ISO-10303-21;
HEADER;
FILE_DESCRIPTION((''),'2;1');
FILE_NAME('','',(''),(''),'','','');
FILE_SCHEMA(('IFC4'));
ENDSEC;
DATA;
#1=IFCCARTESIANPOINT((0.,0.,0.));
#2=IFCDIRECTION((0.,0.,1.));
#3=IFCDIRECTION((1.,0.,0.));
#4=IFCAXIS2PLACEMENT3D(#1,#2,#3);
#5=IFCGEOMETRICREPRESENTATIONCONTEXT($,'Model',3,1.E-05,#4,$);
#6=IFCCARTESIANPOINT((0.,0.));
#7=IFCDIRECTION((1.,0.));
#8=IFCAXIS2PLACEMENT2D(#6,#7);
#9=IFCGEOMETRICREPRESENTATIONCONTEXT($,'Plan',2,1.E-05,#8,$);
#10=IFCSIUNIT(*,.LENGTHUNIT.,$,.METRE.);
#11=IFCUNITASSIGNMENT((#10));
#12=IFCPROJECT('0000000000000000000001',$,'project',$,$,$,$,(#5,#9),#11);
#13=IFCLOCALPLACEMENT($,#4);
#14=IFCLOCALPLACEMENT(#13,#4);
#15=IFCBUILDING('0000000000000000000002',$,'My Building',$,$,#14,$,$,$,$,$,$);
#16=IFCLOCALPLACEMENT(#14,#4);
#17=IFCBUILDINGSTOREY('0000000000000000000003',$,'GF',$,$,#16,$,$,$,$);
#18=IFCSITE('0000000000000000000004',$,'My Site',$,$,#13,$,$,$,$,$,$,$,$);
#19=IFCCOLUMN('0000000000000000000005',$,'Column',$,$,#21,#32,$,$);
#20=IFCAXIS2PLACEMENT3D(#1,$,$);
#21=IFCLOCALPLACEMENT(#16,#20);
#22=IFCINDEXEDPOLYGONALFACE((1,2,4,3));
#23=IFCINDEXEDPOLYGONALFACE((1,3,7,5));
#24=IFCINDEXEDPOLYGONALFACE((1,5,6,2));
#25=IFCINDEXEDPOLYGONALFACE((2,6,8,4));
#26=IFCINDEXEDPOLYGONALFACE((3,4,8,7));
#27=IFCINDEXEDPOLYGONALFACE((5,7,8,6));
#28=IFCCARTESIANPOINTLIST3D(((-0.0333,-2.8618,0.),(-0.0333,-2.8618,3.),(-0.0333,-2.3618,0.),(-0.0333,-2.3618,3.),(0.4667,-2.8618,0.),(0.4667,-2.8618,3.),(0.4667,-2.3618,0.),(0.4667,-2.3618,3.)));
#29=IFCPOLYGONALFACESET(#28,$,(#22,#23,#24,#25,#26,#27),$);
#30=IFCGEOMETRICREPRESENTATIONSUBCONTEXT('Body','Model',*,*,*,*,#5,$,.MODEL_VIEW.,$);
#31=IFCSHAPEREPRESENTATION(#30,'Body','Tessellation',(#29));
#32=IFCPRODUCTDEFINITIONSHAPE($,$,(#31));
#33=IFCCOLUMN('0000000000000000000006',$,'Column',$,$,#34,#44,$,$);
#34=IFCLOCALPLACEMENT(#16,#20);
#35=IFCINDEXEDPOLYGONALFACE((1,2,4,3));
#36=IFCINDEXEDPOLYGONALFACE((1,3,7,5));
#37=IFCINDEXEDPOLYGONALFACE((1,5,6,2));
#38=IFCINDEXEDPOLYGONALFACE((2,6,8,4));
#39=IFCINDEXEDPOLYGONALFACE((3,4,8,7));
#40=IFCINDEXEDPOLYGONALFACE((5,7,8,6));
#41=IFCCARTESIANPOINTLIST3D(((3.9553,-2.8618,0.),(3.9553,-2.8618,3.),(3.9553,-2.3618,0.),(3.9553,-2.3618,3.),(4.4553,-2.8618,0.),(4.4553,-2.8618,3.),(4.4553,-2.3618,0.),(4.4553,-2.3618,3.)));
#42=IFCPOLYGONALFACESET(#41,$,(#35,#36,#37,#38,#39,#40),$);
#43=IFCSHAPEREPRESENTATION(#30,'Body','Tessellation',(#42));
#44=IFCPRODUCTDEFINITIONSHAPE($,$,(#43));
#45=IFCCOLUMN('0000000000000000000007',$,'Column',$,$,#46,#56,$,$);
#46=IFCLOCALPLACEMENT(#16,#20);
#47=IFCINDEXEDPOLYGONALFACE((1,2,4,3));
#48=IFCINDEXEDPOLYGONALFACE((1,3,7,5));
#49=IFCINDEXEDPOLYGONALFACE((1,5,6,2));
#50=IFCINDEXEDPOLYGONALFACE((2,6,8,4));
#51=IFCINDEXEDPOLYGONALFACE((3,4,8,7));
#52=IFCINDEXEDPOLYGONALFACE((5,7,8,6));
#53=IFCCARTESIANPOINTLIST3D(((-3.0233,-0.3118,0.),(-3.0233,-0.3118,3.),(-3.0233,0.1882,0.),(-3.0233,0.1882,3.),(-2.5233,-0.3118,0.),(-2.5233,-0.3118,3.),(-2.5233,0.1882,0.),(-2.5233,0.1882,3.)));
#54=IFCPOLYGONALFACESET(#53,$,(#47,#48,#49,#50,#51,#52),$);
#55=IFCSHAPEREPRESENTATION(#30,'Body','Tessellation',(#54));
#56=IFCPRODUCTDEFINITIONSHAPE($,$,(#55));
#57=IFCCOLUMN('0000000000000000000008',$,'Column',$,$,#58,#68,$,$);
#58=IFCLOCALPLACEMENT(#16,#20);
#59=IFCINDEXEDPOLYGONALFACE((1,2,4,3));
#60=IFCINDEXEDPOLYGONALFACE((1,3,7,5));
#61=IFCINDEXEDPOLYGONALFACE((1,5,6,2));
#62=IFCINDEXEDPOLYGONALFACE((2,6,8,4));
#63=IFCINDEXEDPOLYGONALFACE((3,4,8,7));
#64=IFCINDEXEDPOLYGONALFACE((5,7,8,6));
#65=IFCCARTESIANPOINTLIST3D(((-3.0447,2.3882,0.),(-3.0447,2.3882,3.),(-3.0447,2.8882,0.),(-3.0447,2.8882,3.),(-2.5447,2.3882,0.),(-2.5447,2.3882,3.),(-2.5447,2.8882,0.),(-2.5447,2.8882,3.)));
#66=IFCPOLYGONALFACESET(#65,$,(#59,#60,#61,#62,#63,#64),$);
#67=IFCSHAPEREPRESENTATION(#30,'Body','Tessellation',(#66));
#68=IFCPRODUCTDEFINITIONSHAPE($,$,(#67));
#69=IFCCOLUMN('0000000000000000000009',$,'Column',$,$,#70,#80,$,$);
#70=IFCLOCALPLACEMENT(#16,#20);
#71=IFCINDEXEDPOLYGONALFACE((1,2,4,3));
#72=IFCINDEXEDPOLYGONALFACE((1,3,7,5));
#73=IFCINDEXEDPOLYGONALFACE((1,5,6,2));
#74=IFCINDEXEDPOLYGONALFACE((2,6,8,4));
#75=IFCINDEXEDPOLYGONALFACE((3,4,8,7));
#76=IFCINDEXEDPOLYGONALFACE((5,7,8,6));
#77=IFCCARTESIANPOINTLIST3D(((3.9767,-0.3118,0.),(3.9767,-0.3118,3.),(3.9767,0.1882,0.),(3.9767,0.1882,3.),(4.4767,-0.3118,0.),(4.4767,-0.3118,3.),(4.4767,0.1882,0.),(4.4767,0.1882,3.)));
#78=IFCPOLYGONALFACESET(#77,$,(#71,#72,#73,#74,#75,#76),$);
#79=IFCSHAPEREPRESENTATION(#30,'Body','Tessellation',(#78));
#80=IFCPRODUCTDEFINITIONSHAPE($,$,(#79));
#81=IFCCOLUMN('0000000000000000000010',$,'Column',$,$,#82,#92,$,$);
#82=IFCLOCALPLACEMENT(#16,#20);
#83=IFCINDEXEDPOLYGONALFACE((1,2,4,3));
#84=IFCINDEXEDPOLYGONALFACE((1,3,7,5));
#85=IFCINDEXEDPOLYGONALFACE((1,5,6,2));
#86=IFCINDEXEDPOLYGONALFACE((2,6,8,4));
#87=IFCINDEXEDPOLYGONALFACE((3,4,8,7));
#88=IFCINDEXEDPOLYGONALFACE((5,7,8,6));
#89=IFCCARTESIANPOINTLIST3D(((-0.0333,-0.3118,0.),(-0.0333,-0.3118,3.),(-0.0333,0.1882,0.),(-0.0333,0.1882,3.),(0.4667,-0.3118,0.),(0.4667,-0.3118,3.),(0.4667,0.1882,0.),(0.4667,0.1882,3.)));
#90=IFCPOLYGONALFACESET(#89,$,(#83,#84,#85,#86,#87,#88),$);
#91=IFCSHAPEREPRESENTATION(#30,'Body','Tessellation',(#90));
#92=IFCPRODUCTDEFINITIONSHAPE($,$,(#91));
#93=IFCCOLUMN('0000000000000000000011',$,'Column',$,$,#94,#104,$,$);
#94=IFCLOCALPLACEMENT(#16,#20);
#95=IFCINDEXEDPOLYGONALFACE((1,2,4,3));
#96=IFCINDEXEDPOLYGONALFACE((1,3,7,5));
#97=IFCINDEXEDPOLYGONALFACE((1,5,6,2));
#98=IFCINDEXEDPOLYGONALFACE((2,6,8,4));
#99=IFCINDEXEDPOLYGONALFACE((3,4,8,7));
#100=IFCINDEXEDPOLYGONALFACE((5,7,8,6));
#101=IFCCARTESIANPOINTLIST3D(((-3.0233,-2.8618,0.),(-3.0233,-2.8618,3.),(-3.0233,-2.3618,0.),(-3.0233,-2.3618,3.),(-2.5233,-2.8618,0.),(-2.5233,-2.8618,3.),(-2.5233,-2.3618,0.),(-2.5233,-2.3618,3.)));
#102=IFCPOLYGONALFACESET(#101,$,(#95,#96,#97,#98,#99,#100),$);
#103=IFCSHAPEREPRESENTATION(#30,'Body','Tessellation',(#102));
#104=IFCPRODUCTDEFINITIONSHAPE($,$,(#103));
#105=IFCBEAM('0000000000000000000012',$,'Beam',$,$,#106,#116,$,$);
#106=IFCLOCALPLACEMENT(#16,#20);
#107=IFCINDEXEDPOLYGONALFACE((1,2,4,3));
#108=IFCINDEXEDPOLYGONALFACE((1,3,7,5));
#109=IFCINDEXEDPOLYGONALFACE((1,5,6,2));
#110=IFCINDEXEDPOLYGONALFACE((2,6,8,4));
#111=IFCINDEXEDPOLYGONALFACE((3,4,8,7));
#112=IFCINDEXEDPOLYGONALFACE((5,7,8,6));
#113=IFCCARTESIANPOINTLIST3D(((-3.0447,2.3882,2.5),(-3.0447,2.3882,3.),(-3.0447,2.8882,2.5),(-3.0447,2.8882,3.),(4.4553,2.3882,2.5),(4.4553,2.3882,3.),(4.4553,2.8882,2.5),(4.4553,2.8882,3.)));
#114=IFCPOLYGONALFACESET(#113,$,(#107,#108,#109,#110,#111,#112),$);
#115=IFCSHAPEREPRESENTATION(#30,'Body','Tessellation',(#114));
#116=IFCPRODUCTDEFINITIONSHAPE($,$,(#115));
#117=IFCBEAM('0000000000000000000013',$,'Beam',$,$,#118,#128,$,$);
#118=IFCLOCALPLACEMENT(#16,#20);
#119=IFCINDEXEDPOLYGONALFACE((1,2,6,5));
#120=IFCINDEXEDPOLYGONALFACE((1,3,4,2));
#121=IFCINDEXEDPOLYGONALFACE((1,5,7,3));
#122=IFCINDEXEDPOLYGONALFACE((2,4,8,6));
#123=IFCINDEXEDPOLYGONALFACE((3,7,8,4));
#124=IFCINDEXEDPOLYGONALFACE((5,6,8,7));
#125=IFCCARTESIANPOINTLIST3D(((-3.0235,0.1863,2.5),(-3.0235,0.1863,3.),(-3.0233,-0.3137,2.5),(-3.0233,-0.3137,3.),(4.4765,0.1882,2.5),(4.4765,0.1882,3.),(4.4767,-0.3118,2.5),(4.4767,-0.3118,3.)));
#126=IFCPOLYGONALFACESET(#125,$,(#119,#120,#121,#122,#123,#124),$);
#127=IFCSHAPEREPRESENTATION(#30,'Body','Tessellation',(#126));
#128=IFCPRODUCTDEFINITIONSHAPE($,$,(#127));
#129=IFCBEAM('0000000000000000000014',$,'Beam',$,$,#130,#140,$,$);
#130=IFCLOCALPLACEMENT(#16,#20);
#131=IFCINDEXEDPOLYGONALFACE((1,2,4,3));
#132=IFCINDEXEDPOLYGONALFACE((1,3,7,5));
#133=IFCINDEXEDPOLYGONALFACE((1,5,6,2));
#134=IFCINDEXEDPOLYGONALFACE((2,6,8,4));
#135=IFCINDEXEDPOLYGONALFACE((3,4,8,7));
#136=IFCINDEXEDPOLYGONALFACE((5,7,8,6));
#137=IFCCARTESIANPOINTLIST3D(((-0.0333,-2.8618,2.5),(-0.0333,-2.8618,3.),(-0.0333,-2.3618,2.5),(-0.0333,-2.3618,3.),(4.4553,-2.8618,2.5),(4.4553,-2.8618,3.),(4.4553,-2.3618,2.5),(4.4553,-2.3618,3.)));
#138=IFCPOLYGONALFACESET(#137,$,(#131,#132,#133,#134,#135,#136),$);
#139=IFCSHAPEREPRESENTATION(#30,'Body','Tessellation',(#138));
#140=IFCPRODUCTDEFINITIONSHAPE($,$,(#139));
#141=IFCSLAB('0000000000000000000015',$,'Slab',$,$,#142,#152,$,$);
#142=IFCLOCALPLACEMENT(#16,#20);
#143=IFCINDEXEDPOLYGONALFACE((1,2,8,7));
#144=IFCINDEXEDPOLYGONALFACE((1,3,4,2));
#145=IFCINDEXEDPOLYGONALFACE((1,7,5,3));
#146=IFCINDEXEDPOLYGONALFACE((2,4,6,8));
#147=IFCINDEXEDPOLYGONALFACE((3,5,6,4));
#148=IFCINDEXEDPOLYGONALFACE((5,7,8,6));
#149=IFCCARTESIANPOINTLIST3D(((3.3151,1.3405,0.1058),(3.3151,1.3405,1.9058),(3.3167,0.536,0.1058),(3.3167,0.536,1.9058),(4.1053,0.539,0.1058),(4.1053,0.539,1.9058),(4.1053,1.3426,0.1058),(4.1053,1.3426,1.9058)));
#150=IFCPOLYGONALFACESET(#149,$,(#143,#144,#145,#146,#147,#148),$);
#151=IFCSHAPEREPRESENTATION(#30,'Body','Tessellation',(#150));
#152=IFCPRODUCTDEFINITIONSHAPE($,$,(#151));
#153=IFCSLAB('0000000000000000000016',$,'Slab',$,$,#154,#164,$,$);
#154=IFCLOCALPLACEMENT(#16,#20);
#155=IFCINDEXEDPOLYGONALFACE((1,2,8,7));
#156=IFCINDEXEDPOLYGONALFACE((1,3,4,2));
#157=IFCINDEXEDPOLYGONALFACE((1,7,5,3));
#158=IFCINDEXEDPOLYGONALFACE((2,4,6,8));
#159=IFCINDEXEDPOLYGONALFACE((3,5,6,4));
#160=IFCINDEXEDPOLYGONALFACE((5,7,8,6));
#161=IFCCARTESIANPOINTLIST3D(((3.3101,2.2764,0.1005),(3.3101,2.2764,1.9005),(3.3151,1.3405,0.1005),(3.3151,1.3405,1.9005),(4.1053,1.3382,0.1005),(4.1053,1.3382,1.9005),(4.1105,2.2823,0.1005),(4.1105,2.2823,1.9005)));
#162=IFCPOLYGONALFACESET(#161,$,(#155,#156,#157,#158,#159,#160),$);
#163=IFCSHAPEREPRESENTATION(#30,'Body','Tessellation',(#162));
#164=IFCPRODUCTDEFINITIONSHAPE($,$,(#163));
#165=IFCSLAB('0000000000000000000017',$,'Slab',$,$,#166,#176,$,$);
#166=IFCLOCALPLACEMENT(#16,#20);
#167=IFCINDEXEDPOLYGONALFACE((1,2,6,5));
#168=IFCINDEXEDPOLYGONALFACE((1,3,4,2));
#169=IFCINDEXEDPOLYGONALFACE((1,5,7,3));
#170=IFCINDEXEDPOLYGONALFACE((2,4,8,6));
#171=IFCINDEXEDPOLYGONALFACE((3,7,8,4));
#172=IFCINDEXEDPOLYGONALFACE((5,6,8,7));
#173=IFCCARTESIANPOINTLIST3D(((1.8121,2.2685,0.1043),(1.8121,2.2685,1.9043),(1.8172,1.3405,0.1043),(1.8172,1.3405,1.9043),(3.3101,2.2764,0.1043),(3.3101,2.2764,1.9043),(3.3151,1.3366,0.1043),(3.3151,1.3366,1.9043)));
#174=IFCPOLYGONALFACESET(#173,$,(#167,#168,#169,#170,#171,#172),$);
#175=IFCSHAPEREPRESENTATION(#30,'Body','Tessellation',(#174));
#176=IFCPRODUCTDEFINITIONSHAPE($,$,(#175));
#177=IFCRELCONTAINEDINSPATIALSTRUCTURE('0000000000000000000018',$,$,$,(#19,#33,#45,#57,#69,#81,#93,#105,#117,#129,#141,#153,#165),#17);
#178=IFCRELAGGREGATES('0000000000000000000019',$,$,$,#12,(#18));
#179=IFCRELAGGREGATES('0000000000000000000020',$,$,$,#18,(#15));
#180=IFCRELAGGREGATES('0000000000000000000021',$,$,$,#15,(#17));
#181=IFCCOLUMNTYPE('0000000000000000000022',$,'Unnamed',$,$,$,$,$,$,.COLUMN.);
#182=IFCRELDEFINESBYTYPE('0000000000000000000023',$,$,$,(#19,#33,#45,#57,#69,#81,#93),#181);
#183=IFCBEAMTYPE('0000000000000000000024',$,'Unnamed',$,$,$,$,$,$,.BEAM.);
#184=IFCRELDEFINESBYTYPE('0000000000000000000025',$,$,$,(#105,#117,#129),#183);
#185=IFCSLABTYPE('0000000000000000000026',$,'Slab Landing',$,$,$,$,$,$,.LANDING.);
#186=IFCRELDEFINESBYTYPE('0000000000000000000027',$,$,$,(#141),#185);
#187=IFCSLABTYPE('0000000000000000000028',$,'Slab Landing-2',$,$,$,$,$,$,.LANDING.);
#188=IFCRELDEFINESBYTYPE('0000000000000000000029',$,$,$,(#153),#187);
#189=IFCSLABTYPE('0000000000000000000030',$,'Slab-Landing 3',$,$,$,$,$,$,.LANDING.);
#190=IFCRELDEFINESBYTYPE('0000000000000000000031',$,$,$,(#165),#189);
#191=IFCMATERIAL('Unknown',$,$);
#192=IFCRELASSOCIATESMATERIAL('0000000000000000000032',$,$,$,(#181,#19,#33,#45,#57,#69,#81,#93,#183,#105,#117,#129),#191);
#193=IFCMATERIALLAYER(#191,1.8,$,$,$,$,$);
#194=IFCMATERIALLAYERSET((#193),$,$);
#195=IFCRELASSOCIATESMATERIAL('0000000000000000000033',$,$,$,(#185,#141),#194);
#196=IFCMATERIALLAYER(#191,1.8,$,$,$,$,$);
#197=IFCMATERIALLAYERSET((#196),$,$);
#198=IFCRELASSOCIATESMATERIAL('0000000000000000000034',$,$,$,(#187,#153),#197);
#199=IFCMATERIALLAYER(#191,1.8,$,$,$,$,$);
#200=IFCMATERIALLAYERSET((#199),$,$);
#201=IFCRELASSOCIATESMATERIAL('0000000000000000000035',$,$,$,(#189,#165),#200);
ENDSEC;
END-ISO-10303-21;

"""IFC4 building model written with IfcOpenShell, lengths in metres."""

from ifc_helpers import new_model, si_unit, frame, origin_with_axes, origin_2d_with_axis, place, context, subcontext, project, spatial, indexed_curve, rectangle, outline, extrude, material, layer, layer_set, layer_usage, material_profile, profile_set, profile_usage, type_object, element, save


model = new_model("IFC4")

# Units and contexts
model_context = context("Model", 3, precision=1e-05, world=origin_with_axes())
plan_context = context("Plan", 2, precision=1e-05, world=origin_2d_with_axis())
body_context_1 = subcontext(model_context, "Body", "Model", "MODEL_VIEW")
ifc_project = project(units=[si_unit("LENGTHUNIT", "METRE")], contexts=[model_context, plan_context])

# Site, building, storey
site_placement = place(None, origin_with_axes())
site = spatial("IfcSite", under=ifc_project, at=site_placement, Name="My Site")
building_placement = place(site_placement, origin_with_axes())
building = spatial("IfcBuilding", under=site, at=building_placement, Name="My Building")
storey_placement = place(building_placement, origin_with_axes())
storey = spatial("IfcBuildingStorey", under=building, at=storey_placement, Name="GF")

# Columns
ifc_material = material(Name="Unknown")
ifc_material_profile_1 = material_profile(ifc_material, rectangle(XDim=0.5, YDim=0.5))
ifc_profile_set_1 = profile_set([ifc_material_profile_1])
ifc_profile_usage_1 = profile_usage(ifc_profile_set_1, cardinal=5)
column_type = type_object("IfcColumnType", Name="Unnamed", PredefinedType="COLUMN", material=ifc_profile_set_1)
column_1_placement = place(storey_placement, frame((0.2167, -2.6118, 0.0), z_axis=(0.0, 0.0, 1.0), x_axis=(1.0, 0.0, 0.0)))
element("IfcColumn", 1, at=column_1_placement, inside=storey, type_object=column_type, material=ifc_profile_usage_1, Name="Column", context=body_context_1, shape_type="SweptSolid", body=[
    extrude(rectangle(XDim=0.5, YDim=0.5), origin_with_axes(), (0.0, 0.0, 1.0), 3.0),
])
ifc_profile_usage_2 = profile_usage(ifc_profile_set_1, cardinal=5)
column_2_placement = place(storey_placement, frame((4.2053, -2.6118, 0.0), z_axis=(0.0, 0.0, 1.0), x_axis=(1.0, 0.0, 0.0)))
element("IfcColumn", 2, at=column_2_placement, inside=storey, type_object=column_type, material=ifc_profile_usage_2, Name="Column", context=body_context_1, shape_type="SweptSolid", body=[
    extrude(rectangle(XDim=0.5, YDim=0.5), origin_with_axes(), (0.0, 0.0, 1.0), 3.0),
])
ifc_profile_usage_3 = profile_usage(ifc_profile_set_1, cardinal=5)
column_3_placement = place(storey_placement, frame((-2.7733, -0.0618, 0.0), z_axis=(0.0, 0.0, 1.0), x_axis=(1.0, 0.0, 0.0)))
element("IfcColumn", 3, at=column_3_placement, inside=storey, type_object=column_type, material=ifc_profile_usage_3, Name="Column", context=body_context_1, shape_type="SweptSolid", body=[
    extrude(rectangle(XDim=0.5, YDim=0.5), origin_with_axes(), (0.0, 0.0, 1.0), 3.0),
])
ifc_profile_usage_4 = profile_usage(ifc_profile_set_1, cardinal=5)
column_4_placement = place(storey_placement, frame((-2.7947, 2.6382, 0.0), z_axis=(0.0, 0.0, 1.0), x_axis=(1.0, 0.0, 0.0)))
element("IfcColumn", 4, at=column_4_placement, inside=storey, type_object=column_type, material=ifc_profile_usage_4, Name="Column", context=body_context_1, shape_type="SweptSolid", body=[
    extrude(rectangle(XDim=0.5, YDim=0.5), origin_with_axes(), (0.0, 0.0, 1.0), 3.0),
])
ifc_profile_usage_5 = profile_usage(ifc_profile_set_1, cardinal=5)
column_5_placement = place(storey_placement, frame((4.2267, -0.0618, 0.0), z_axis=(0.0, 0.0, 1.0), x_axis=(1.0, 0.0, 0.0)))
element("IfcColumn", 5, at=column_5_placement, inside=storey, type_object=column_type, material=ifc_profile_usage_5, Name="Column", context=body_context_1, shape_type="SweptSolid", body=[
    extrude(rectangle(XDim=0.5, YDim=0.5), origin_with_axes(), (0.0, 0.0, 1.0), 3.0),
])
ifc_profile_usage_6 = profile_usage(ifc_profile_set_1, cardinal=5)
column_6_placement = place(storey_placement, frame((0.2167, -0.0618, 0.0), z_axis=(0.0, 0.0, 1.0), x_axis=(1.0, 0.0, 0.0)))
element("IfcColumn", 6, at=column_6_placement, inside=storey, type_object=column_type, material=ifc_profile_usage_6, Name="Column", context=body_context_1, shape_type="SweptSolid", body=[
    extrude(rectangle(XDim=0.5, YDim=0.5), origin_with_axes(), (0.0, 0.0, 1.0), 3.0),
])
ifc_profile_usage_7 = profile_usage(ifc_profile_set_1, cardinal=5)
column_7_placement = place(storey_placement, frame((-2.7733, -2.6118, 0.0), z_axis=(0.0, 0.0, 1.0), x_axis=(1.0, 0.0, 0.0)))
element("IfcColumn", 7, at=column_7_placement, inside=storey, type_object=column_type, material=ifc_profile_usage_7, Name="Column", context=body_context_1, shape_type="SweptSolid", body=[
    extrude(rectangle(XDim=0.5, YDim=0.5), origin_with_axes(), (0.0, 0.0, 1.0), 3.0),
])

# Beams
ifc_material_profile_2 = material_profile(ifc_material, rectangle(XDim=0.5, YDim=0.5))
ifc_profile_set_2 = profile_set([ifc_material_profile_2])
ifc_profile_usage_8 = profile_usage(ifc_profile_set_2, cardinal=7)
beam_type = type_object("IfcBeamType", Name="Unnamed", PredefinedType="BEAM", material=ifc_profile_set_2)
beam_1_placement = place(storey_placement, frame((4.4553, 2.3882, 3.0), z_axis=(-1.0, 0.0, 0.0), x_axis=(0.0, -1.0, 0.0)))
element("IfcBeam", 8, at=beam_1_placement, inside=storey, type_object=beam_type, material=ifc_profile_usage_8, Name="Beam", context=body_context_1, shape_type="SweptSolid", body=[
    extrude(rectangle(XDim=0.5, YDim=0.5), frame((-0.25, -0.25, 0.0), z_axis=(0.0, 0.0, 1.0), x_axis=(1.0, 0.0, 0.0)), (0.0, 0.0, 1.0), 7.5),
])
ifc_profile_usage_9 = profile_usage(ifc_profile_set_2, cardinal=7)
beam_2_placement = place(storey_placement, frame((4.4767, -0.3118, 3.0), z_axis=(-1.0, -0.000255, 0.0), x_axis=(0.000255, -1.0, 0.0)))
element("IfcBeam", 9, at=beam_2_placement, inside=storey, type_object=beam_type, material=ifc_profile_usage_9, Name="Beam", context=body_context_1, shape_type="SweptSolid", body=[
    extrude(rectangle(XDim=0.5, YDim=0.5), frame((-0.25, -0.25, 0.0), z_axis=(0.0, 0.0, 1.0), x_axis=(1.0, 0.0, 0.0)), (0.0, 0.0, 1.0), 7.5),
])
ifc_profile_usage_10 = profile_usage(ifc_profile_set_2, cardinal=7)
beam_3_placement = place(storey_placement, frame((4.4553, -2.8618, 3.0), z_axis=(-1.0, 0.0, 0.0), x_axis=(0.0, -1.0, 0.0)))
element("IfcBeam", 10, at=beam_3_placement, inside=storey, type_object=beam_type, material=ifc_profile_usage_10, Name="Beam", context=body_context_1, shape_type="SweptSolid", body=[
    extrude(rectangle(XDim=0.5, YDim=0.5), frame((-0.25, -0.25, 0.0), z_axis=(0.0, 0.0, 1.0), x_axis=(1.0, 0.0, 0.0)), (0.0, 0.0, 1.0), 4.4886),
])

# Slabs
ifc_layer_1 = layer(ifc_material, 1.8)
ifc_layer_set_1 = layer_set([ifc_layer_1])
ifc_layer_usage_1 = layer_usage(ifc_layer_set_1, "AXIS3", "POSITIVE", -0.1)
slab_type_1 = type_object("IfcSlabType", Name="Slab Landing", PredefinedType="LANDING", material=ifc_layer_set_1)
slab_1_placement = place(storey_placement, frame((3.3167, 0.536, 0.2058), z_axis=(0.0, 0.0, 1.0), x_axis=(1.0, 0.0, 0.0)))
element("IfcSlab", 11, at=slab_1_placement, inside=storey, type_object=slab_type_1, material=ifc_layer_usage_1, Name="Slab", context=body_context_1, shape_type="SweptSolid", body=[
    extrude(outline(indexed_curve([(-0.0016, 0.8044), (0.7886, 0.8066), (0.7886, 0.003), (0.0, 0.0), (-0.0016, 0.8044)])), frame((0.0, 0.0, -0.1), z_axis=(0.0, 0.0, 1.0), x_axis=(1.0, 0.0, 0.0)), (0.0, 0.0, 1.0), 1.8),
])
ifc_layer_2 = layer(ifc_material, 1.8)
ifc_layer_set_2 = layer_set([ifc_layer_2])
ifc_layer_usage_2 = layer_usage(ifc_layer_set_2, "AXIS3", "POSITIVE", -1.8)
slab_type_2 = type_object("IfcSlabType", Name="Slab Landing-2", PredefinedType="LANDING", material=ifc_layer_set_2)
slab_2_placement = place(storey_placement, frame((3.3151, 1.3405, 1.9005), z_axis=(0.0, 0.0, 1.0), x_axis=(1.0, 0.0, 0.0)))
element("IfcSlab", 12, at=slab_2_placement, inside=storey, type_object=slab_type_2, material=ifc_layer_usage_2, Name="Slab", context=body_context_1, shape_type="SweptSolid", body=[
    extrude(outline(indexed_curve([(0.0, 0.0), (-0.005, 0.936), (0.7954, 0.9418), (0.7902, -0.0023), (0.0, 0.0)])), frame((0.0, 0.0, -1.8), z_axis=(0.0, 0.0, 1.0), x_axis=(1.0, 0.0, 0.0)), (0.0, 0.0, 1.0), 1.8),
])
ifc_layer_3 = layer(ifc_material, 1.8)
ifc_layer_set_3 = layer_set([ifc_layer_3])
ifc_layer_usage_3 = layer_usage(ifc_layer_set_3, "AXIS3", "POSITIVE", -1.8)
slab_type_3 = type_object("IfcSlabType", Name="Slab-Landing 3", PredefinedType="LANDING", material=ifc_layer_set_3)
slab_3_placement = place(storey_placement, frame((1.8172, 1.3405, 1.9043), z_axis=(0.0, 0.0, 1.0), x_axis=(1.0, 0.0, 0.0)))
element("IfcSlab", 13, at=slab_3_placement, inside=storey, type_object=slab_type_3, material=ifc_layer_usage_3, Name="Slab", context=body_context_1, shape_type="SweptSolid", body=[
    extrude(outline(indexed_curve([(0.0, 0.0), (1.4979, -0.0039), (1.4929, 0.936), (-0.0051, 0.928), (0.0, 0.0)])), frame((0.0, 0.0, -1.8), z_axis=(0.0, 0.0, 1.0), x_axis=(1.0, 0.0, 0.0)), (0.0, 0.0, 1.0), 1.8),
])

save(model, "model.ifc")
